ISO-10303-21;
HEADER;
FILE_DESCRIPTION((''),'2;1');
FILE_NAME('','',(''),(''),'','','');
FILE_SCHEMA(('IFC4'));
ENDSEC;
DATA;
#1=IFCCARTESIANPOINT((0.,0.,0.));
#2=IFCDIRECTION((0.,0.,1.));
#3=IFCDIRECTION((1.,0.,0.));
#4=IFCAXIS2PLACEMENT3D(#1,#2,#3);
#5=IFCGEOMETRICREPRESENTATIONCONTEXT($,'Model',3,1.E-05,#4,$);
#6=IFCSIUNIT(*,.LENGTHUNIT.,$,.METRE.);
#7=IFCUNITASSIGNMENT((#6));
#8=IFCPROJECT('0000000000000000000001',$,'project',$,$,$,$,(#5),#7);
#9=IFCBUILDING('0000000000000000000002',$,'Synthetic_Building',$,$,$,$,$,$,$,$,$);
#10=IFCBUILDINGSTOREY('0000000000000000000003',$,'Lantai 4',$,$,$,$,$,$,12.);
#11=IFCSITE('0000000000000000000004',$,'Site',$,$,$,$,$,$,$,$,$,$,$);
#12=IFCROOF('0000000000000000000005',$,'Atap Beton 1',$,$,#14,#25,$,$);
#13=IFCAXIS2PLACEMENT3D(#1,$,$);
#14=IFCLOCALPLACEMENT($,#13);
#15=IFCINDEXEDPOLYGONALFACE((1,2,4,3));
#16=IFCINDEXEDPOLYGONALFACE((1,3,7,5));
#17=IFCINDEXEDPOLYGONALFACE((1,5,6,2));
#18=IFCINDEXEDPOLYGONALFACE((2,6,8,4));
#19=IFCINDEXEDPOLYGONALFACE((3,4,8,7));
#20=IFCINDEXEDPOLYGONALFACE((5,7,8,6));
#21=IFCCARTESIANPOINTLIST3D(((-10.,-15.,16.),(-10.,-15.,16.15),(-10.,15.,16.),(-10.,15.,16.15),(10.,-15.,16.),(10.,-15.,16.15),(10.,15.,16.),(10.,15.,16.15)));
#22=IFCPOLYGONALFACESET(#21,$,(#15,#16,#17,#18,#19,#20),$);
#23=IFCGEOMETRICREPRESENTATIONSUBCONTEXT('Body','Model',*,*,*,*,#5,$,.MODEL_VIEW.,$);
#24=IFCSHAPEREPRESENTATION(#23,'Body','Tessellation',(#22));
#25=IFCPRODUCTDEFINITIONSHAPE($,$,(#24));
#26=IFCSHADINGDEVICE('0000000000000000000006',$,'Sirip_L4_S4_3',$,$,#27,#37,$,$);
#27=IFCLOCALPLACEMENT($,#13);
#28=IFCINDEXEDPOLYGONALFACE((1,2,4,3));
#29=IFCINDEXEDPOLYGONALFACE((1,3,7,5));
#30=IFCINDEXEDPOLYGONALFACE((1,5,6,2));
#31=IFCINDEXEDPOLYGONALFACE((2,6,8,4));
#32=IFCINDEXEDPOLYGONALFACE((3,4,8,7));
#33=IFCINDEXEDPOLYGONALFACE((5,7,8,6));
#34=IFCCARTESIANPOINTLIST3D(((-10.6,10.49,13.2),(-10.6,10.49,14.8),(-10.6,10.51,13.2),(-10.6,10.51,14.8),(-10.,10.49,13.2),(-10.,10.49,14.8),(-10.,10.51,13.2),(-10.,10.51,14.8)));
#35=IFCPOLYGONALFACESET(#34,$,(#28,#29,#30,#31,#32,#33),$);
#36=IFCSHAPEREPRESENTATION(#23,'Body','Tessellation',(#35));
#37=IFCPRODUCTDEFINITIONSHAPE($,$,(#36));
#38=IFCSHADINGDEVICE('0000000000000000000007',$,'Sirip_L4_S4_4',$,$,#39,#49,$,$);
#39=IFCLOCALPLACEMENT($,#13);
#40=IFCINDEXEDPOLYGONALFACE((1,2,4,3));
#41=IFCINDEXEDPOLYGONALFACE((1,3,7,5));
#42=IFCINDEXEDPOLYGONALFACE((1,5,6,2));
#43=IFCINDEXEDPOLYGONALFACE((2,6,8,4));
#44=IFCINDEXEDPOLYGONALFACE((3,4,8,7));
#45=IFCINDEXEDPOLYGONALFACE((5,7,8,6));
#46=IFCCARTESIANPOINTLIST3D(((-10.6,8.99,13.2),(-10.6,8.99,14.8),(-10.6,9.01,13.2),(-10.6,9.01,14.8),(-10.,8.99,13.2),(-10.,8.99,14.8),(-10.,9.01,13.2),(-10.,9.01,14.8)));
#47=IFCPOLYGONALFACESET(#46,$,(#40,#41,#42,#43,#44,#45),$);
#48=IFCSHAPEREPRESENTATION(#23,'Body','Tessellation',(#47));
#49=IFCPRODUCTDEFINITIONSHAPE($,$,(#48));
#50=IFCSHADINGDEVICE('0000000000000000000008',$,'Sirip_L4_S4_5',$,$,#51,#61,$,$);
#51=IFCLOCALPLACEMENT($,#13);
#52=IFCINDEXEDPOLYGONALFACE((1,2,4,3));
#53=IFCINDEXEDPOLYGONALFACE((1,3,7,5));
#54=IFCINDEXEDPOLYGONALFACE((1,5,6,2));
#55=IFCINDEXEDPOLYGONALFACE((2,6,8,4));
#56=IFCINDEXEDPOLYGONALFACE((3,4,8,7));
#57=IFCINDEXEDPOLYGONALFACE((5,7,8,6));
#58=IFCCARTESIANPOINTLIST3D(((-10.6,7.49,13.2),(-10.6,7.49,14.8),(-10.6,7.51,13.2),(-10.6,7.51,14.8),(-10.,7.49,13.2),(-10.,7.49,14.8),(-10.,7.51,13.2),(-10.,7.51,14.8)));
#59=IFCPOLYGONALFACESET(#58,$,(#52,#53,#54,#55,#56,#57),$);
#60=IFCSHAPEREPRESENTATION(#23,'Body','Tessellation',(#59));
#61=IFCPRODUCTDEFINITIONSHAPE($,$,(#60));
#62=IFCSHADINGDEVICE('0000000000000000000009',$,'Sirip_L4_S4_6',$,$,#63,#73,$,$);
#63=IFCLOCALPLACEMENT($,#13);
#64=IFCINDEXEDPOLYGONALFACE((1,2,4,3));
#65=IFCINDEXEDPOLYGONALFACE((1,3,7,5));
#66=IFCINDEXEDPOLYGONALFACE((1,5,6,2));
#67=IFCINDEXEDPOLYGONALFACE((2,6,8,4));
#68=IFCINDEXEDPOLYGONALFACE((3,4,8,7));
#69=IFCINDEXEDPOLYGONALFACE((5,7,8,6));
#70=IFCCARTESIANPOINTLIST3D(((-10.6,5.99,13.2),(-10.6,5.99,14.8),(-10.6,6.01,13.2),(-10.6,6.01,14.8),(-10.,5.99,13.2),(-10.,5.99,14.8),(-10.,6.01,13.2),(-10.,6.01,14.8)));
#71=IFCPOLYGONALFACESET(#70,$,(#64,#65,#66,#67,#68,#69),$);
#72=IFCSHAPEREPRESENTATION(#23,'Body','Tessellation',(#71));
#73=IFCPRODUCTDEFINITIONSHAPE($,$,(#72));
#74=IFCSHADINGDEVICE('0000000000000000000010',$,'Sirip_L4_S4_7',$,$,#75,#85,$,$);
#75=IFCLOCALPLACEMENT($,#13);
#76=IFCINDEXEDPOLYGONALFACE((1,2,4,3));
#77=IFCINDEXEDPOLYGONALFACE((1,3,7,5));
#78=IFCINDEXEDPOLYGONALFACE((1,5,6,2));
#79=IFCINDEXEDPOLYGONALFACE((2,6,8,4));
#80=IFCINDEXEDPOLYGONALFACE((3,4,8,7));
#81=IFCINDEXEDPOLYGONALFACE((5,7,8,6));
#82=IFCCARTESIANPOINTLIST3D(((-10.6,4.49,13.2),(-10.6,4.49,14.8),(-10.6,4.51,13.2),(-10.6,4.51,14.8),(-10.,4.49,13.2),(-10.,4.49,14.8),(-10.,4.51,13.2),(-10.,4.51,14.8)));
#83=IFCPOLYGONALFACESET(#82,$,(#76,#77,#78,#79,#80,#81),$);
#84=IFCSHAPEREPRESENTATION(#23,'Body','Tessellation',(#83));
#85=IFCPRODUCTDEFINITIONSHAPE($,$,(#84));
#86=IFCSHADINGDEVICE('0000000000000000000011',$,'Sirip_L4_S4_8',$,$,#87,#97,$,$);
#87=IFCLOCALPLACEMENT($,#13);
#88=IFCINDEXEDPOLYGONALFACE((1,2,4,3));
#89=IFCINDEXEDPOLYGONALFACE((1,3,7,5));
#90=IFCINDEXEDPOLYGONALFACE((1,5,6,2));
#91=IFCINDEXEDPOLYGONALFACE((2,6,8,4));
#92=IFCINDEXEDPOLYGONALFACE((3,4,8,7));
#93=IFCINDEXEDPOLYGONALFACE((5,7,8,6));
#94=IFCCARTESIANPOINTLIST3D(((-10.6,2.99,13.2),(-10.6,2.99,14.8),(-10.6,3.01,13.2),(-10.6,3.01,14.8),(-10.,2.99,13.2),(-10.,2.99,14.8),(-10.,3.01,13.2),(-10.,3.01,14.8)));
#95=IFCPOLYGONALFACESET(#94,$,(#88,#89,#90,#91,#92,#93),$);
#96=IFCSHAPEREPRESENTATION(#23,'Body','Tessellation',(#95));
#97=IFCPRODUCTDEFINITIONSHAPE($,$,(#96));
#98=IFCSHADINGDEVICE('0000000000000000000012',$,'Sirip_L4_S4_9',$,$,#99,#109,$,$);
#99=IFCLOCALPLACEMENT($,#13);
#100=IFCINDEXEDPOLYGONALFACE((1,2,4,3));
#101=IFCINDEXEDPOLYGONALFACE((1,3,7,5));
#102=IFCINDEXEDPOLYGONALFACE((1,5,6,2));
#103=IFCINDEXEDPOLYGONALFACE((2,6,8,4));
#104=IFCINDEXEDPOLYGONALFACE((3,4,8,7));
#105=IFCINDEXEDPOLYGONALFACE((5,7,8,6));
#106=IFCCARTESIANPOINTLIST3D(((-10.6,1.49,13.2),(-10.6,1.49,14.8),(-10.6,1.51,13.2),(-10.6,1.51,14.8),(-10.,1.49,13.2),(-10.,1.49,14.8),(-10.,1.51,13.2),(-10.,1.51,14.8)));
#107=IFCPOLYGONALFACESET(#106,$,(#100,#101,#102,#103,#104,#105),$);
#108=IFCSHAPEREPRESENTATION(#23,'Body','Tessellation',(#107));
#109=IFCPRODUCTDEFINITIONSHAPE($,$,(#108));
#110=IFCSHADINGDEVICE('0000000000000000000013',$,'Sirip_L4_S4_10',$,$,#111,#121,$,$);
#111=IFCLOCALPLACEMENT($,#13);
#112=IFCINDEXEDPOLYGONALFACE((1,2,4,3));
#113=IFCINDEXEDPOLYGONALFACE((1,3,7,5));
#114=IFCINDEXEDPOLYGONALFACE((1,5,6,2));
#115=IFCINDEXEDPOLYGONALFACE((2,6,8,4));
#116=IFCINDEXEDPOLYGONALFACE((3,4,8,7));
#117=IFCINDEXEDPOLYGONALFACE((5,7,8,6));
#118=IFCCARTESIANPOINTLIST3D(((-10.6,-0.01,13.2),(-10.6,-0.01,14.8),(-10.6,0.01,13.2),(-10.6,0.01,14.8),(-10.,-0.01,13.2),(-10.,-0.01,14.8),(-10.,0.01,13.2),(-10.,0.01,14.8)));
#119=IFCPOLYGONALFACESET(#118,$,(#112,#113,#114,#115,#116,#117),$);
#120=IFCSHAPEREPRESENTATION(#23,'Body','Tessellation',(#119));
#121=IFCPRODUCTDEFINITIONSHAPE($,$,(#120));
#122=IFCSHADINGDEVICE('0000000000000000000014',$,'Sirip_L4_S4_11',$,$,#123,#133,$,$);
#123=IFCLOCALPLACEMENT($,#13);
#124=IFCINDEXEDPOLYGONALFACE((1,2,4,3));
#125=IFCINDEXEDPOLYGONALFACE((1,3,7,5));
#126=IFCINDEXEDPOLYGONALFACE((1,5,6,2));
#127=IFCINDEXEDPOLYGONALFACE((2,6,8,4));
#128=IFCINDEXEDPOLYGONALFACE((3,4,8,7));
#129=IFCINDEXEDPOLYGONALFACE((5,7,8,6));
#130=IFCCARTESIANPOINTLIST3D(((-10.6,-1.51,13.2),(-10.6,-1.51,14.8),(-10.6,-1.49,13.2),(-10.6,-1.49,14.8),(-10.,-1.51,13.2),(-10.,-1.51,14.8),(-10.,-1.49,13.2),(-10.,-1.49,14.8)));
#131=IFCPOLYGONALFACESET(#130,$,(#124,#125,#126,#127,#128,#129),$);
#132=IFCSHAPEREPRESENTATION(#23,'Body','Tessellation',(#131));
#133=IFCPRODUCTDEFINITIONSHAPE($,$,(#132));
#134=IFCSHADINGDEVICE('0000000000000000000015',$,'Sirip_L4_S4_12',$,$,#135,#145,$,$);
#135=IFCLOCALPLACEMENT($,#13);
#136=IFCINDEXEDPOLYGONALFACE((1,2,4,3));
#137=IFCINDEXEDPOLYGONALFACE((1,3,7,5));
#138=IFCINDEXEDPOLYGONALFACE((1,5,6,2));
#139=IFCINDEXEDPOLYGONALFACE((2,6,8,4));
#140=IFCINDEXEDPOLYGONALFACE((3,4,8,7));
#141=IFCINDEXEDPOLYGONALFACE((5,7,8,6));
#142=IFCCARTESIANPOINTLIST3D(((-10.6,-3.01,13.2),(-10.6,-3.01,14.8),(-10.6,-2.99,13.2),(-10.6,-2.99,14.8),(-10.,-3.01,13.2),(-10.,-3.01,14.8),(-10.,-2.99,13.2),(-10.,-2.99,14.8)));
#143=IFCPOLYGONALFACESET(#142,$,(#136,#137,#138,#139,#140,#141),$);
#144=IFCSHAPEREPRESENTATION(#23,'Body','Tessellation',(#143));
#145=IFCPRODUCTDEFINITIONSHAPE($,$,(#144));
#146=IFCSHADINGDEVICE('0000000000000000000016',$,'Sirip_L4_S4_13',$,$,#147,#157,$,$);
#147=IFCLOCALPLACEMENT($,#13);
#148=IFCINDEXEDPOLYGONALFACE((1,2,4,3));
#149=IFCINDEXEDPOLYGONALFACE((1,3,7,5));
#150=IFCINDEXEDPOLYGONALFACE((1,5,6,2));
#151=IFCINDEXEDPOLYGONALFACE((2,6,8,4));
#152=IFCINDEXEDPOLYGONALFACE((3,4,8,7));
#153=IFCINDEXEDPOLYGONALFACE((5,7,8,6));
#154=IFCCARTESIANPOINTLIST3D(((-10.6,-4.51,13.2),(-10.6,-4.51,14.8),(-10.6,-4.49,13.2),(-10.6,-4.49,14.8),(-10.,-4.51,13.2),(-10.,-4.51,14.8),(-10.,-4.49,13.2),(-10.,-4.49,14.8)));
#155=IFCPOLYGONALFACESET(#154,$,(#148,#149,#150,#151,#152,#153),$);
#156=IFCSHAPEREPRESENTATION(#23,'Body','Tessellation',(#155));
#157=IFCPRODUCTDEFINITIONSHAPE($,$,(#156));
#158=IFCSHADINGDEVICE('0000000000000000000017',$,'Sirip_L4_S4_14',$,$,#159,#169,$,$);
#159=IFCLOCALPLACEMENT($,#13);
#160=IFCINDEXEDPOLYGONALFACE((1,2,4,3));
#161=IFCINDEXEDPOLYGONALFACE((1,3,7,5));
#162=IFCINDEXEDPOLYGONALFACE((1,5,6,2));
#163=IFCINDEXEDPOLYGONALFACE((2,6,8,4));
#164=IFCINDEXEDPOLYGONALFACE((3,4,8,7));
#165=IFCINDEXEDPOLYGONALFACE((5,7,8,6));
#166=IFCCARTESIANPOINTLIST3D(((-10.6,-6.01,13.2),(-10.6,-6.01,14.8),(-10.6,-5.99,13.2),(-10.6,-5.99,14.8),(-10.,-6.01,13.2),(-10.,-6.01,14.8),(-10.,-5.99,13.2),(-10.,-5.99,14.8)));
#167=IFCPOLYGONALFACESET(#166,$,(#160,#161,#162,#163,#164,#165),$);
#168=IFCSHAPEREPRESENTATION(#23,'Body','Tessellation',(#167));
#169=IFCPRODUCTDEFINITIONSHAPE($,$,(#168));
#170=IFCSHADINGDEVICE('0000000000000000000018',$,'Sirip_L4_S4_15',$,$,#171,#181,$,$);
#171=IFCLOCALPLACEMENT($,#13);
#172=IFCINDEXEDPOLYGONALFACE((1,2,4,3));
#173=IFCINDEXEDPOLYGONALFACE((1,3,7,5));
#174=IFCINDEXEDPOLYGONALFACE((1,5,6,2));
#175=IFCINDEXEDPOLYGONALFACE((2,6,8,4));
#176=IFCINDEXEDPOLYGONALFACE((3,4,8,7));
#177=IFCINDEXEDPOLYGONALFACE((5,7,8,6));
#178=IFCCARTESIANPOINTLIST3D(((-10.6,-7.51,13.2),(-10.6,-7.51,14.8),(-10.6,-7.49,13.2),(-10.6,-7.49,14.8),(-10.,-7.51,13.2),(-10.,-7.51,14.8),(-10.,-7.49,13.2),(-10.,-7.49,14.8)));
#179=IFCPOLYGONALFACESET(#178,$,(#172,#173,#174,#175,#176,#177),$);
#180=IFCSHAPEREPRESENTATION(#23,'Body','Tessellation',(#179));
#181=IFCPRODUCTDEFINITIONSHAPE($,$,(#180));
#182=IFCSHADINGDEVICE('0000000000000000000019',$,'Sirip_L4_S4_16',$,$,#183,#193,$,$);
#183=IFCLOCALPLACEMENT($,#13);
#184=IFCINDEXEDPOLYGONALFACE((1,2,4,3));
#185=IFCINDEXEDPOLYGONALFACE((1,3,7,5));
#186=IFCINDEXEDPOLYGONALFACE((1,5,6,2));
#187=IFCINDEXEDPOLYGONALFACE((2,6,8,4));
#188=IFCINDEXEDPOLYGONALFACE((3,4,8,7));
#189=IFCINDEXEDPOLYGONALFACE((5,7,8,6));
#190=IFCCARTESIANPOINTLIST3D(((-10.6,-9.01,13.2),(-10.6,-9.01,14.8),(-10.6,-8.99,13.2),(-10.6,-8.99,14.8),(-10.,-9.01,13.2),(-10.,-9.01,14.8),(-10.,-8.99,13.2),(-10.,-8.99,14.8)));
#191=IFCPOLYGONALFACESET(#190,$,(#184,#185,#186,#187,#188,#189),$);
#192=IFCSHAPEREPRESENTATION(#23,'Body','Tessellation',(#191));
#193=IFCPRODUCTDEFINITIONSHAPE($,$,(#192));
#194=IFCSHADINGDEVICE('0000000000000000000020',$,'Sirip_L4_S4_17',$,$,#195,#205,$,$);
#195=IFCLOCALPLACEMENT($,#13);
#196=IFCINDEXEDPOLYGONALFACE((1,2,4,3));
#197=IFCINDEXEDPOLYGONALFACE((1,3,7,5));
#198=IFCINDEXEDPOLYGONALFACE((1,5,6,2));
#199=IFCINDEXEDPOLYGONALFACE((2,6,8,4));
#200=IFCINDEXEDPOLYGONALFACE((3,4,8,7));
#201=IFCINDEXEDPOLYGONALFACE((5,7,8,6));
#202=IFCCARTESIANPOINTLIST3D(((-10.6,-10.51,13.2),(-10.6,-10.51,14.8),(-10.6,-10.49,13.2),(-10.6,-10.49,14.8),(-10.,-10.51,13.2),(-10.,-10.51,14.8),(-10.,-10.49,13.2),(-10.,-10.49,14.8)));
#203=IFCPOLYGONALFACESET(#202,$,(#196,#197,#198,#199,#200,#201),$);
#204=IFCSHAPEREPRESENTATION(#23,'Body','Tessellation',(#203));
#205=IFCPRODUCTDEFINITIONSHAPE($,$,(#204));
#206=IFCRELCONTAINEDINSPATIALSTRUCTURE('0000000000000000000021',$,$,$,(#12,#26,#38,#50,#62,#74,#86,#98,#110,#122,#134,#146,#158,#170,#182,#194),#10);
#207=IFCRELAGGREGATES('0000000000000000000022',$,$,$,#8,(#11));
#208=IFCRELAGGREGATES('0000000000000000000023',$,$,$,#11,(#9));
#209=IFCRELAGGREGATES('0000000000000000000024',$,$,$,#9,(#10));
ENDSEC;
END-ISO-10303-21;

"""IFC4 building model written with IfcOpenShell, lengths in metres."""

from ifc_helpers import new_model, si_unit, frame, origin_with_axes, place, context, subcontext, project, spatial, polyline, outline, extrude, element, save


model = new_model("IFC4")

# Units and contexts
model_context = context("Model", 3, precision=1e-05, world=origin_with_axes())
body_context = subcontext(model_context, "Body", "Model", "MODEL_VIEW")
ifc_project = project(units=[si_unit("LENGTHUNIT", "METRE")], contexts=[model_context])

# Site, building, storey
site = spatial("IfcSite", under=ifc_project, Name="Site")
building = spatial("IfcBuilding", under=site, Name="Synthetic_Building")
storey = spatial("IfcBuildingStorey", under=building, Name="Lantai 4", Elevation=12.0)

# Roof
roof_placement = place(None, origin_with_axes())
element("IfcRoof", 1, at=roof_placement, inside=storey, Name="Atap Beton 1", context=body_context, shape_type="SweptSolid", body=[
    extrude(outline(polyline([(-10.0, -15.0), (10.0, -15.0), (10.0, 15.0), (-10.0, 15.0), (-10.0, -15.0)])), frame((0.0, 0.0, 16.0), z_axis=(0.0, 0.0, 1.0), x_axis=(1.0, 0.0, 0.0)), (0.0, 0.0, 1.0), 0.15),
])

# Shading devices
shading_device_1_placement = place(None, origin_with_axes())
element("IfcShadingDevice", 2, at=shading_device_1_placement, inside=storey, Name="Sirip_L4_S4_3", context=body_context, shape_type="SweptSolid", body=[
    extrude(outline(polyline([(-10.0, 10.51), (-10.0, 10.49), (-10.6, 10.49), (-10.6, 10.51), (-10.0, 10.51)])), frame((0.0, 0.0, 13.2), z_axis=(0.0, 0.0, 1.0), x_axis=(1.0, 0.0, 0.0)), (0.0, 0.0, 1.0), 1.6),
])
shading_device_2_placement = place(None, origin_with_axes())
element("IfcShadingDevice", 3, at=shading_device_2_placement, inside=storey, Name="Sirip_L4_S4_4", context=body_context, shape_type="SweptSolid", body=[
    extrude(outline(polyline([(-10.0, 9.01), (-10.0, 8.99), (-10.6, 8.99), (-10.6, 9.01), (-10.0, 9.01)])), frame((0.0, 0.0, 13.2), z_axis=(0.0, 0.0, 1.0), x_axis=(1.0, 0.0, 0.0)), (0.0, 0.0, 1.0), 1.6),
])
shading_device_3_placement = place(None, origin_with_axes())
element("IfcShadingDevice", 4, at=shading_device_3_placement, inside=storey, Name="Sirip_L4_S4_5", context=body_context, shape_type="SweptSolid", body=[
    extrude(outline(polyline([(-10.0, 7.51), (-10.0, 7.49), (-10.6, 7.49), (-10.6, 7.51), (-10.0, 7.51)])), frame((0.0, 0.0, 13.2), z_axis=(0.0, 0.0, 1.0), x_axis=(1.0, 0.0, 0.0)), (0.0, 0.0, 1.0), 1.6),
])
shading_device_4_placement = place(None, origin_with_axes())
element("IfcShadingDevice", 5, at=shading_device_4_placement, inside=storey, Name="Sirip_L4_S4_6", context=body_context, shape_type="SweptSolid", body=[
    extrude(outline(polyline([(-10.0, 6.01), (-10.0, 5.99), (-10.6, 5.99), (-10.6, 6.01), (-10.0, 6.01)])), frame((0.0, 0.0, 13.2), z_axis=(0.0, 0.0, 1.0), x_axis=(1.0, 0.0, 0.0)), (0.0, 0.0, 1.0), 1.6),
])
shading_device_5_placement = place(None, origin_with_axes())
element("IfcShadingDevice", 6, at=shading_device_5_placement, inside=storey, Name="Sirip_L4_S4_7", context=body_context, shape_type="SweptSolid", body=[
    extrude(outline(polyline([(-10.0, 4.51), (-10.0, 4.49), (-10.6, 4.49), (-10.6, 4.51), (-10.0, 4.51)])), frame((0.0, 0.0, 13.2), z_axis=(0.0, 0.0, 1.0), x_axis=(1.0, 0.0, 0.0)), (0.0, 0.0, 1.0), 1.6),
])
shading_device_6_placement = place(None, origin_with_axes())
element("IfcShadingDevice", 7, at=shading_device_6_placement, inside=storey, Name="Sirip_L4_S4_8", context=body_context, shape_type="SweptSolid", body=[
    extrude(outline(polyline([(-10.0, 3.01), (-10.0, 2.99), (-10.6, 2.99), (-10.6, 3.01), (-10.0, 3.01)])), frame((0.0, 0.0, 13.2), z_axis=(0.0, 0.0, 1.0), x_axis=(1.0, 0.0, 0.0)), (0.0, 0.0, 1.0), 1.6),
])
shading_device_7_placement = place(None, origin_with_axes())
element("IfcShadingDevice", 8, at=shading_device_7_placement, inside=storey, Name="Sirip_L4_S4_9", context=body_context, shape_type="SweptSolid", body=[
    extrude(outline(polyline([(-10.0, 1.51), (-10.0, 1.49), (-10.6, 1.49), (-10.6, 1.51), (-10.0, 1.51)])), frame((0.0, 0.0, 13.2), z_axis=(0.0, 0.0, 1.0), x_axis=(1.0, 0.0, 0.0)), (0.0, 0.0, 1.0), 1.6),
])
shading_device_8_placement = place(None, origin_with_axes())
element("IfcShadingDevice", 9, at=shading_device_8_placement, inside=storey, Name="Sirip_L4_S4_10", context=body_context, shape_type="SweptSolid", body=[
    extrude(outline(polyline([(-10.0, 0.01), (-10.0, -0.01), (-10.6, -0.01), (-10.6, 0.01), (-10.0, 0.01)])), frame((0.0, 0.0, 13.2), z_axis=(0.0, 0.0, 1.0), x_axis=(1.0, 0.0, 0.0)), (0.0, 0.0, 1.0), 1.6),
])
shading_device_9_placement = place(None, origin_with_axes())
element("IfcShadingDevice", 10, at=shading_device_9_placement, inside=storey, Name="Sirip_L4_S4_11", context=body_context, shape_type="SweptSolid", body=[
    extrude(outline(polyline([(-10.0, -1.49), (-10.0, -1.51), (-10.6, -1.51), (-10.6, -1.49), (-10.0, -1.49)])), frame((0.0, 0.0, 13.2), z_axis=(0.0, 0.0, 1.0), x_axis=(1.0, 0.0, 0.0)), (0.0, 0.0, 1.0), 1.6),
])
shading_device_10_placement = place(None, origin_with_axes())
element("IfcShadingDevice", 11, at=shading_device_10_placement, inside=storey, Name="Sirip_L4_S4_12", context=body_context, shape_type="SweptSolid", body=[
    extrude(outline(polyline([(-10.0, -2.99), (-10.0, -3.01), (-10.6, -3.01), (-10.6, -2.99), (-10.0, -2.99)])), frame((0.0, 0.0, 13.2), z_axis=(0.0, 0.0, 1.0), x_axis=(1.0, 0.0, 0.0)), (0.0, 0.0, 1.0), 1.6),
])
shading_device_11_placement = place(None, origin_with_axes())
element("IfcShadingDevice", 12, at=shading_device_11_placement, inside=storey, Name="Sirip_L4_S4_13", context=body_context, shape_type="SweptSolid", body=[
    extrude(outline(polyline([(-10.0, -4.49), (-10.0, -4.51), (-10.6, -4.51), (-10.6, -4.49), (-10.0, -4.49)])), frame((0.0, 0.0, 13.2), z_axis=(0.0, 0.0, 1.0), x_axis=(1.0, 0.0, 0.0)), (0.0, 0.0, 1.0), 1.6),
])
shading_device_12_placement = place(None, origin_with_axes())
element("IfcShadingDevice", 13, at=shading_device_12_placement, inside=storey, Name="Sirip_L4_S4_14", context=body_context, shape_type="SweptSolid", body=[
    extrude(outline(polyline([(-10.0, -5.99), (-10.0, -6.01), (-10.6, -6.01), (-10.6, -5.99), (-10.0, -5.99)])), frame((0.0, 0.0, 13.2), z_axis=(0.0, 0.0, 1.0), x_axis=(1.0, 0.0, 0.0)), (0.0, 0.0, 1.0), 1.6),
])
shading_device_13_placement = place(None, origin_with_axes())
element("IfcShadingDevice", 14, at=shading_device_13_placement, inside=storey, Name="Sirip_L4_S4_15", context=body_context, shape_type="SweptSolid", body=[
    extrude(outline(polyline([(-10.0, -7.49), (-10.0, -7.51), (-10.6, -7.51), (-10.6, -7.49), (-10.0, -7.49)])), frame((0.0, 0.0, 13.2), z_axis=(0.0, 0.0, 1.0), x_axis=(1.0, 0.0, 0.0)), (0.0, 0.0, 1.0), 1.6),
])
shading_device_14_placement = place(None, origin_with_axes())
element("IfcShadingDevice", 15, at=shading_device_14_placement, inside=storey, Name="Sirip_L4_S4_16", context=body_context, shape_type="SweptSolid", body=[
    extrude(outline(polyline([(-10.0, -8.99), (-10.0, -9.01), (-10.6, -9.01), (-10.6, -8.99), (-10.0, -8.99)])), frame((0.0, 0.0, 13.2), z_axis=(0.0, 0.0, 1.0), x_axis=(1.0, 0.0, 0.0)), (0.0, 0.0, 1.0), 1.6),
])
shading_device_15_placement = place(None, origin_with_axes())
element("IfcShadingDevice", 16, at=shading_device_15_placement, inside=storey, Name="Sirip_L4_S4_17", context=body_context, shape_type="SweptSolid", body=[
    extrude(outline(polyline([(-10.0, -10.49), (-10.0, -10.51), (-10.6, -10.51), (-10.6, -10.49), (-10.0, -10.49)])), frame((0.0, 0.0, 13.2), z_axis=(0.0, 0.0, 1.0), x_axis=(1.0, 0.0, 0.0)), (0.0, 0.0, 1.0), 1.6),
])

save(model, "model.ifc")
